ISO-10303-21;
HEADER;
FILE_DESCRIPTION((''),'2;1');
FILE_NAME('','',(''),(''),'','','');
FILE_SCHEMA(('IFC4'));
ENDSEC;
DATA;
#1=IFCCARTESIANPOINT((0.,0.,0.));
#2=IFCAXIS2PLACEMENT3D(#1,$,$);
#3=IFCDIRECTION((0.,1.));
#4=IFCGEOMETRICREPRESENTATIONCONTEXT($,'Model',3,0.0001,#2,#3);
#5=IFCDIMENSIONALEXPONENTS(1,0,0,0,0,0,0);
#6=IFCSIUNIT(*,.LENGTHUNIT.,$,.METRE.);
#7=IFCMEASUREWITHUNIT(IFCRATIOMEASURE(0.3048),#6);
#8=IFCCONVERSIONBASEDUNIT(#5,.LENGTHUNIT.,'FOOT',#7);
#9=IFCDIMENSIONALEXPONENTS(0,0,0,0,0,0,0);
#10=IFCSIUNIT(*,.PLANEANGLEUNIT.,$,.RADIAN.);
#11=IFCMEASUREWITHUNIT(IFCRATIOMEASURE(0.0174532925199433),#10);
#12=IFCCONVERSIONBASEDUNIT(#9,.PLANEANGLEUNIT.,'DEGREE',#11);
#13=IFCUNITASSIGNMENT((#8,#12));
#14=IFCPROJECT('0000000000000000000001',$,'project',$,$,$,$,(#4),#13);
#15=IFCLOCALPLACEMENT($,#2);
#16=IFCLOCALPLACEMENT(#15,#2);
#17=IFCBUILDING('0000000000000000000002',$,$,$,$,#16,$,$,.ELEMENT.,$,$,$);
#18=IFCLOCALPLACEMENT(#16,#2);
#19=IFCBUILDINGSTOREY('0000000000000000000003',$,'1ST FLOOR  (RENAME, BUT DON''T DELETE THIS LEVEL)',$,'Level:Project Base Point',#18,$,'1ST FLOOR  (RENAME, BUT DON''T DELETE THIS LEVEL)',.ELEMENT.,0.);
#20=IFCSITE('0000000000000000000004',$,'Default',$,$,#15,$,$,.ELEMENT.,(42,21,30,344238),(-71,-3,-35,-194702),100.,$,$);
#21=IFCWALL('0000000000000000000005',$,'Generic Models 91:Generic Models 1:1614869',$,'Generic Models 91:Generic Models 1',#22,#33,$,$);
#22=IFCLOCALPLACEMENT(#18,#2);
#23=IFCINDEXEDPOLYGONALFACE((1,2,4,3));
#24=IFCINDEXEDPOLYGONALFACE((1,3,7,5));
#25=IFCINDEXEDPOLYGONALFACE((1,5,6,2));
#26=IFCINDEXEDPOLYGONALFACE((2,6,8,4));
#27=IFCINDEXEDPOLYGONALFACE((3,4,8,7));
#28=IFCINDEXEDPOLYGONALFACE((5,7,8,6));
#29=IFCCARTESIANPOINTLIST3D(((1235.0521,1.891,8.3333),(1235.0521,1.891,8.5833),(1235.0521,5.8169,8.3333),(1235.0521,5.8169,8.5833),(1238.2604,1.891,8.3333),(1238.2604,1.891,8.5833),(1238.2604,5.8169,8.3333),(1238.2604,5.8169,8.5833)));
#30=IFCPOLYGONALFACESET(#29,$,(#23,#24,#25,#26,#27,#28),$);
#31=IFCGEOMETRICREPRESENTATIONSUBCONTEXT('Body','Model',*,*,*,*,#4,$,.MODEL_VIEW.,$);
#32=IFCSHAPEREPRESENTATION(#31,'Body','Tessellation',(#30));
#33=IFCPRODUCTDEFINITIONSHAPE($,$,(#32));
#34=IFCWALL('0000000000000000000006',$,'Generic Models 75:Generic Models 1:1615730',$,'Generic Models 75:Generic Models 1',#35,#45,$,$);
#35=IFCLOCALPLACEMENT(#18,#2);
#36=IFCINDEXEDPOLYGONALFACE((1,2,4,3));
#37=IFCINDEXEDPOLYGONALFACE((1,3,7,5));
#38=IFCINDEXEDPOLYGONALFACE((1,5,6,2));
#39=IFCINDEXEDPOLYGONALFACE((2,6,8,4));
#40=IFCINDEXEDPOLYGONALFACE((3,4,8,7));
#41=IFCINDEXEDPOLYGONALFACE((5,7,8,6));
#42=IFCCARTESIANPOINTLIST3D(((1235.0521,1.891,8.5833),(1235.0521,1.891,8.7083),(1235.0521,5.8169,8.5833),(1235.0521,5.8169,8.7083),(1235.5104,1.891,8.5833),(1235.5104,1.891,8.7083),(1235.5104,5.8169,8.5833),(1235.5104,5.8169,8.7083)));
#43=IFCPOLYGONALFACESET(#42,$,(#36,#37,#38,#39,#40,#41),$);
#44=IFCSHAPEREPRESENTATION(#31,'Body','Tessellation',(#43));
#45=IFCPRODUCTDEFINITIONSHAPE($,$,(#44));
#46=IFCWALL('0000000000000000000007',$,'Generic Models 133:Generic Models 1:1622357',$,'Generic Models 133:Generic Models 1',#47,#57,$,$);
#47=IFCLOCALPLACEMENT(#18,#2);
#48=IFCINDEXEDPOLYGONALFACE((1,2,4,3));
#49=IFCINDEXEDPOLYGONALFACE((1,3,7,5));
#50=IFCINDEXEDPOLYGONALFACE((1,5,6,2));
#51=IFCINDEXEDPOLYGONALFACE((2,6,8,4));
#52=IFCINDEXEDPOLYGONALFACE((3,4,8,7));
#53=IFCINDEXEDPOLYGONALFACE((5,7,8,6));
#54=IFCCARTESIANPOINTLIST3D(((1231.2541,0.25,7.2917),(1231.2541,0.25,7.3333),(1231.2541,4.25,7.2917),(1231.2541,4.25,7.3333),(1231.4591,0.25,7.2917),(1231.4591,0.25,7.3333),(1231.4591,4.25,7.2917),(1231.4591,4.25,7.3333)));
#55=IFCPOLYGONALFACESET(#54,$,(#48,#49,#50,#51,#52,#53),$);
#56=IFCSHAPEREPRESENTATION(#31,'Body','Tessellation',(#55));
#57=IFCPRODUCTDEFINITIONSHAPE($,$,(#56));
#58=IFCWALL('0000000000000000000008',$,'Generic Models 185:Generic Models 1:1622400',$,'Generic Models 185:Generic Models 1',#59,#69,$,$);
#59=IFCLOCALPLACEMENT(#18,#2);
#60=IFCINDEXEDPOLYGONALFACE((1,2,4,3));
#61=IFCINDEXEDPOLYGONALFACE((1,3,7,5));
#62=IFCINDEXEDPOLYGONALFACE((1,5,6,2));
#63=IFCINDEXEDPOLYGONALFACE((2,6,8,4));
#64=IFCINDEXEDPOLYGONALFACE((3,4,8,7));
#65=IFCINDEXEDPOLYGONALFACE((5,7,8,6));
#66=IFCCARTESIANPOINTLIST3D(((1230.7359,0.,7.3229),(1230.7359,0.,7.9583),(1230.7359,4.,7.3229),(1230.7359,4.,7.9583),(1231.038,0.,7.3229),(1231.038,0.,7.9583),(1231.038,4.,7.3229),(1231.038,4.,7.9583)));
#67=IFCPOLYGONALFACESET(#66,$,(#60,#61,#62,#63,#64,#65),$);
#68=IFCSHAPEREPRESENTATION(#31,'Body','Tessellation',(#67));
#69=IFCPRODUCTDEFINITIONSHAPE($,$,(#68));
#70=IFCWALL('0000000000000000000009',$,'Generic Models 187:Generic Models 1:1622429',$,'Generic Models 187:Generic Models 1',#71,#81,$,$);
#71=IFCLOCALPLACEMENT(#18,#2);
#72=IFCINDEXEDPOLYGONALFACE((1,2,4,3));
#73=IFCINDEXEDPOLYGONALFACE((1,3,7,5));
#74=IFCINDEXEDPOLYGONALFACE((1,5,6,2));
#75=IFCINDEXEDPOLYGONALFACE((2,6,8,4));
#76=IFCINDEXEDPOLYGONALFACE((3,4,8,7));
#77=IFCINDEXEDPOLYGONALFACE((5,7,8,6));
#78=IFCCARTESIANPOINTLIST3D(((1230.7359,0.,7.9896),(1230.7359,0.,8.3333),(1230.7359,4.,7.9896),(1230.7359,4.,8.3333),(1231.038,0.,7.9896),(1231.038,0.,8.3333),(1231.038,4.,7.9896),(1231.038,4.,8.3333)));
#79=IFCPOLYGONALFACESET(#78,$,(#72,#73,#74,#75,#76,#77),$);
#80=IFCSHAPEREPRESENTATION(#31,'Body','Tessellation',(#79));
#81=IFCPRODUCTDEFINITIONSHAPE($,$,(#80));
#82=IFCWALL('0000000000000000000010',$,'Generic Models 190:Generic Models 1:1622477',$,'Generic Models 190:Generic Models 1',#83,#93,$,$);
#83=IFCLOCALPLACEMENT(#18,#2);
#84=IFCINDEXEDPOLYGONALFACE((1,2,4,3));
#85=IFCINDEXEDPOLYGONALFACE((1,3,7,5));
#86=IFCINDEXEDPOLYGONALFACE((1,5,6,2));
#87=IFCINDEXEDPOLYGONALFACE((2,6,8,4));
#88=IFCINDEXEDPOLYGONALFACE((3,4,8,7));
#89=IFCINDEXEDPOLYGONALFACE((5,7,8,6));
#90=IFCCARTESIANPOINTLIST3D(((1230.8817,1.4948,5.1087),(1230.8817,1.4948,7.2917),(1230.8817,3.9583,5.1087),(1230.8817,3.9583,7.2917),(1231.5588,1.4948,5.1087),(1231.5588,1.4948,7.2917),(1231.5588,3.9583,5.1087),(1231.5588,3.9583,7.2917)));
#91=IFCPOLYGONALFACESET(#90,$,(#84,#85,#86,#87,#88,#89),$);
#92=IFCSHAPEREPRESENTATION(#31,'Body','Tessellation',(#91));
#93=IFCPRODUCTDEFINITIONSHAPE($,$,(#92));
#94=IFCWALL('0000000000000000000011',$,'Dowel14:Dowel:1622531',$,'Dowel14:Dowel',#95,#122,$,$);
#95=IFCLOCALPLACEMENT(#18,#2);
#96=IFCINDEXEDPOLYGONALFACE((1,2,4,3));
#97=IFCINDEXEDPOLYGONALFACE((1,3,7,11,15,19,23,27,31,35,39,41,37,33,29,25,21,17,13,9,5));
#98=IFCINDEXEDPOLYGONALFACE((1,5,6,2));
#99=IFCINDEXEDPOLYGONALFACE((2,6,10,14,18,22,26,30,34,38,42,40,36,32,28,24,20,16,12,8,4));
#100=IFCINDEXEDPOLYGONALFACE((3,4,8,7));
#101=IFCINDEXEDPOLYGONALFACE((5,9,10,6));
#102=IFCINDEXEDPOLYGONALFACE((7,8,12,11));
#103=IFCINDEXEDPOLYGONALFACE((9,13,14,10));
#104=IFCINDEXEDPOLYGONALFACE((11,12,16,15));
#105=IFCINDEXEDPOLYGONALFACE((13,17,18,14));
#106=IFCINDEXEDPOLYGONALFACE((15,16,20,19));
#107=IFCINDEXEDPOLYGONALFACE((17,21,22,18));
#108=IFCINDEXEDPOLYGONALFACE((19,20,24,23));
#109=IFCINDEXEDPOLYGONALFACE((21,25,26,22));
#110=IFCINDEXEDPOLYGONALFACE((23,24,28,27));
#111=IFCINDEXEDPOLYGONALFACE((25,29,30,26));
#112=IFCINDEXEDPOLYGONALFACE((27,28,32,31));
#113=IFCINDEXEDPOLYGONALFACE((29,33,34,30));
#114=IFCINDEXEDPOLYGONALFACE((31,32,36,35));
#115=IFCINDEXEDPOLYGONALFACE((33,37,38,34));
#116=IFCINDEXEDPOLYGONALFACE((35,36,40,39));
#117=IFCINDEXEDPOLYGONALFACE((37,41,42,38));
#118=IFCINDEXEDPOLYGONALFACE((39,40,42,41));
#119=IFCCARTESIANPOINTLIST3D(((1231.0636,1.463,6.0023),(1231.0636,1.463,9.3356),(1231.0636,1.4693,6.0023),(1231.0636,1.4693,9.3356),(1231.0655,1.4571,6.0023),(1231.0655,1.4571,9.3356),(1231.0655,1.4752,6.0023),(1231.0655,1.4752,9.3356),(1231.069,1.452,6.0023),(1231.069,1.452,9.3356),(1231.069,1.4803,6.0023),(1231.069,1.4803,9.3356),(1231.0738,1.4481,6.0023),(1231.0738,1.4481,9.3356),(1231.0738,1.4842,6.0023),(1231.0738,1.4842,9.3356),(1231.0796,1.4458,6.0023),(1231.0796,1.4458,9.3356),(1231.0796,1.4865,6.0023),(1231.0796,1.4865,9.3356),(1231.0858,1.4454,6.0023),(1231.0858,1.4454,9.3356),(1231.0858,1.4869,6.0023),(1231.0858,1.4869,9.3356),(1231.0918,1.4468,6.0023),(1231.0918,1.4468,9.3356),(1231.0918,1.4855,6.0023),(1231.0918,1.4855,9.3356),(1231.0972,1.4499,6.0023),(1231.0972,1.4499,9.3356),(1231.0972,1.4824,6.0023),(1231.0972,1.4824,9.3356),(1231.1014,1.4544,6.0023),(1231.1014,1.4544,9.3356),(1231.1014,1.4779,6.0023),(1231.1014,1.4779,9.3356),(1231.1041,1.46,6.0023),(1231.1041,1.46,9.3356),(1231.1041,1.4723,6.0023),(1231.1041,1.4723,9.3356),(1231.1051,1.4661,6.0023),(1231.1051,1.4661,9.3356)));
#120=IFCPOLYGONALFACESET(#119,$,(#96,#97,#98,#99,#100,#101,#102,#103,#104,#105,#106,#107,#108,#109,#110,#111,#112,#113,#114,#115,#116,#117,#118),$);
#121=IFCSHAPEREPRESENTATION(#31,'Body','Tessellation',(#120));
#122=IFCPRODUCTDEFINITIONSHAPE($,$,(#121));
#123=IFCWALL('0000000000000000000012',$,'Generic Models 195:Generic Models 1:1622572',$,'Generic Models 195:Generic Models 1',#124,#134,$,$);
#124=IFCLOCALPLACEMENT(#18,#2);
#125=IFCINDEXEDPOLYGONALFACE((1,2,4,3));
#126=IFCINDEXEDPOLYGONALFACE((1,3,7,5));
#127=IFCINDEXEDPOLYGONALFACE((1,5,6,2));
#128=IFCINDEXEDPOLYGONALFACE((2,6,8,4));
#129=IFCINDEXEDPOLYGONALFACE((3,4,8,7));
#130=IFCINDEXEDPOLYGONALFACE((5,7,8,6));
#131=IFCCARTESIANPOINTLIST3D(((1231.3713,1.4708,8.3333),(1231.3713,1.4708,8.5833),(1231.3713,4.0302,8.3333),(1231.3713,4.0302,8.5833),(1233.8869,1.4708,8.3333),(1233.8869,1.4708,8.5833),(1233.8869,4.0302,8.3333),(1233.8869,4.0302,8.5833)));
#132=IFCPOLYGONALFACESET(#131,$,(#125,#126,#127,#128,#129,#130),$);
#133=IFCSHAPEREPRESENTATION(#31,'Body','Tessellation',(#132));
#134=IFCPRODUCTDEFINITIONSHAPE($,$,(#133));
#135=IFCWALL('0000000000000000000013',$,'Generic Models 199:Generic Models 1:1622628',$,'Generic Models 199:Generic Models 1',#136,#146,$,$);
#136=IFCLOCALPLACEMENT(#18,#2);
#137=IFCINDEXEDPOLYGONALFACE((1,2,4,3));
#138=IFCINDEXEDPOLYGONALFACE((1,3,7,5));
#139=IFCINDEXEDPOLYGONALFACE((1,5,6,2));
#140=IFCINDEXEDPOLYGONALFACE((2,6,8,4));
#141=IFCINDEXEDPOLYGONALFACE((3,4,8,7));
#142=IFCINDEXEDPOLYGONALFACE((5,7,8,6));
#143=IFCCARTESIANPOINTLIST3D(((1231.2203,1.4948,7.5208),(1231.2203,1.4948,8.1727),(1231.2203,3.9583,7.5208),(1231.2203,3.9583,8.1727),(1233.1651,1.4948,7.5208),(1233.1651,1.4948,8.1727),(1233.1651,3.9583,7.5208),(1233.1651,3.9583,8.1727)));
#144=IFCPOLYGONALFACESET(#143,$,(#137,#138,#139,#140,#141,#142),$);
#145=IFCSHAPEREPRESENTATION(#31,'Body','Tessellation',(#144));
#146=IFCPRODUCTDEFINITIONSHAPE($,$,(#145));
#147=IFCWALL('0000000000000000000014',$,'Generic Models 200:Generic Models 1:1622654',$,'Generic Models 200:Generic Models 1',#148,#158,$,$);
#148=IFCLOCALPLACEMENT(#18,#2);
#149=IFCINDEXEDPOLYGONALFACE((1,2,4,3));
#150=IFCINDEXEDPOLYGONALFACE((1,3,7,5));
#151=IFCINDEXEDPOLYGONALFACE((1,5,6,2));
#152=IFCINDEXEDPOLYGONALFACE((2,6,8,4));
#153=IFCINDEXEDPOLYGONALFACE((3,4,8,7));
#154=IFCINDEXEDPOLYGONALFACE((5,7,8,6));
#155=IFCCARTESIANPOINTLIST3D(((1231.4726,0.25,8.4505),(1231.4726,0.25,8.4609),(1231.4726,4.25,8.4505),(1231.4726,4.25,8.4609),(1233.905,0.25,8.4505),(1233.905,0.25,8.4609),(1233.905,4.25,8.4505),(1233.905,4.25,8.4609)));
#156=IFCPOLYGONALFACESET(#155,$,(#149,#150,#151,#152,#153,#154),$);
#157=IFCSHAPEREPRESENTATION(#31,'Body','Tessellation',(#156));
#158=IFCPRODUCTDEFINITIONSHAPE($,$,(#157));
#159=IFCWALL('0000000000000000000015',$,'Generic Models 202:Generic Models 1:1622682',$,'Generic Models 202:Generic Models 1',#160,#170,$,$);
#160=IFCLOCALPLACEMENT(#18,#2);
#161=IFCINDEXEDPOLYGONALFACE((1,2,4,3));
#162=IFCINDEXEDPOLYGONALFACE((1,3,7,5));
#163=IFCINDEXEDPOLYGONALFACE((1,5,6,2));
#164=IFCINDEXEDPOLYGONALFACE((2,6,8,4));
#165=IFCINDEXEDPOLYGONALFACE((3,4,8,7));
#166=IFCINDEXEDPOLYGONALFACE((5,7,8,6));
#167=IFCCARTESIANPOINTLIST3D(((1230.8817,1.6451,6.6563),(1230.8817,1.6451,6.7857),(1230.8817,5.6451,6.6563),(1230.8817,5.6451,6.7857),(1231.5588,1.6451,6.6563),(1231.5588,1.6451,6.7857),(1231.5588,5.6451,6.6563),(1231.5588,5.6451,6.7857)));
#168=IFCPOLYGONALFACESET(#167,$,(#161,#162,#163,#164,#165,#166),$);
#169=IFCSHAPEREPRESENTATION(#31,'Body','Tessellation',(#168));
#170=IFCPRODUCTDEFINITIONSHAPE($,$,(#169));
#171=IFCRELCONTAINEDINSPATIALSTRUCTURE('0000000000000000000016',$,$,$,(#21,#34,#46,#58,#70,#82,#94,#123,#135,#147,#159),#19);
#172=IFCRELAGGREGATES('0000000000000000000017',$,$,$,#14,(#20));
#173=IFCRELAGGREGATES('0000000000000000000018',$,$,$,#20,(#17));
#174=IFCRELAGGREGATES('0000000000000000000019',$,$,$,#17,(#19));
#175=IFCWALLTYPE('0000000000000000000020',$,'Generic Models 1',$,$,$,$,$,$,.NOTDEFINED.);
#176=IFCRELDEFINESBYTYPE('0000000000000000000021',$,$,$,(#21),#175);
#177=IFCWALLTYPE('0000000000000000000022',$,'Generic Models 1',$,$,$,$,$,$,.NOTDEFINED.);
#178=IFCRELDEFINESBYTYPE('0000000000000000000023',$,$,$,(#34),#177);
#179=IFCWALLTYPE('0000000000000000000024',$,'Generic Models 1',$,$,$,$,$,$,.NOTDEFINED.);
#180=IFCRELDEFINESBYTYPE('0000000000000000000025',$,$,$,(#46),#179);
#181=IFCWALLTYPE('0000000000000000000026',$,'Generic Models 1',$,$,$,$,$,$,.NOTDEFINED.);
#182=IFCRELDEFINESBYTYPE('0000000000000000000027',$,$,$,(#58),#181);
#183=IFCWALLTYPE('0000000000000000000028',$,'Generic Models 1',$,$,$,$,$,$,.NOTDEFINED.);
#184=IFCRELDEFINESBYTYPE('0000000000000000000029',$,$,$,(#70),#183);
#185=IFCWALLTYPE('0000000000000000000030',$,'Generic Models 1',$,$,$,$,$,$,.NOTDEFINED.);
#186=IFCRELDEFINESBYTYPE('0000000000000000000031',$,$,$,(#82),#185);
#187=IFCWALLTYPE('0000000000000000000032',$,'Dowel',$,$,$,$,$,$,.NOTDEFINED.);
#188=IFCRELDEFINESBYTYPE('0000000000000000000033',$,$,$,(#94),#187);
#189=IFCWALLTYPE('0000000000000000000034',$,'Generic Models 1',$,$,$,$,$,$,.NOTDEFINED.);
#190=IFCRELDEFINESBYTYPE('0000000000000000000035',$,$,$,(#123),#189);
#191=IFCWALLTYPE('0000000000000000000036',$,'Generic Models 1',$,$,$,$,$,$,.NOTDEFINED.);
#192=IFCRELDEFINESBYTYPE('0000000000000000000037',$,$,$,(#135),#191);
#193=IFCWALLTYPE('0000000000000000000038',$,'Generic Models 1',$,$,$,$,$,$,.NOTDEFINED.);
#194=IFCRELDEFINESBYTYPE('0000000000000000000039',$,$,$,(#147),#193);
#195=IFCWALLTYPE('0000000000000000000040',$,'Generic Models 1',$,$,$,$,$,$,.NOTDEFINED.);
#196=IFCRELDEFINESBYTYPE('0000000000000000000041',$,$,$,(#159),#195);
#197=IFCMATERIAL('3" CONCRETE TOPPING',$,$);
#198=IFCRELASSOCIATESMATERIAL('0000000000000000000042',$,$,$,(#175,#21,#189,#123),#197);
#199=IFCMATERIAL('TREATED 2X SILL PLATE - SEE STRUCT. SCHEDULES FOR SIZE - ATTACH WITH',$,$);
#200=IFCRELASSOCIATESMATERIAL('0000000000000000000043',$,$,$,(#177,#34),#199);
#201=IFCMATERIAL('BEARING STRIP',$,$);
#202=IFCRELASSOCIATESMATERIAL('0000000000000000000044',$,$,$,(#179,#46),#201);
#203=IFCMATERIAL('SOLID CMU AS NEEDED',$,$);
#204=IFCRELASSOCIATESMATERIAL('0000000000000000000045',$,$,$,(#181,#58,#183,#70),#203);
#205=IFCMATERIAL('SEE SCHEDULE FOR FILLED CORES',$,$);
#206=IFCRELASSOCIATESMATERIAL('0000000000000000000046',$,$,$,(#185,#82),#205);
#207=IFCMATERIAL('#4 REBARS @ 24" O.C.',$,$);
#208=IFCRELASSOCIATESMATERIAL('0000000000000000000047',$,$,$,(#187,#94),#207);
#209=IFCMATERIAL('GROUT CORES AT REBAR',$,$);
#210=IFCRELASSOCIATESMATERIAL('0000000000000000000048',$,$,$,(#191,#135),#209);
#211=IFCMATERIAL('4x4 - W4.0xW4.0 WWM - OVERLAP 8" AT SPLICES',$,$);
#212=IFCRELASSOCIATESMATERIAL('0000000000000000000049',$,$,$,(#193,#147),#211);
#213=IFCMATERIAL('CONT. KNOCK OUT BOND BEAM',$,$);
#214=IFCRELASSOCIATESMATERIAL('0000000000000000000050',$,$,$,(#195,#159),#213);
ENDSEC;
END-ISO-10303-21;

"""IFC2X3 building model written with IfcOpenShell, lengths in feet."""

from ifc_helpers import new_model, entity, si_unit, converted_unit, direction, frame, frame_2d, origin, origin_2d_with_axis, place, context, subcontext, project, spatial, rectangle, circle, extrude, material, type_object, element, save


model = new_model("IFC2X3")

# Units and contexts
model_context = context("Model", 3, precision=0.0001, world=origin(), true_north=direction((0.0, 1.0)))
body_context = subcontext(model_context, "Body", "Model", "MODEL_VIEW")
ifc_project = project(units=[converted_unit("LENGTHUNIT", "FOOT", entity("IfcRatioMeasure", 0.3048), si_unit("LENGTHUNIT", "METRE"), dimensions=[1, 0, 0, 0, 0, 0, 0]), converted_unit("PLANEANGLEUNIT", "DEGREE", entity("IfcRatioMeasure", 0.0174532925199433), si_unit("PLANEANGLEUNIT", "RADIAN"), dimensions=[0, 0, 0, 0, 0, 0, 0])], contexts=[model_context])

# Site, building, storey
site_placement = place(None, origin())
site = spatial("IfcSite", under=ifc_project, at=site_placement, Name="Default", CompositionType="ELEMENT", RefLatitude=(42, 21, 30, 344238), RefLongitude=(-71, -3, -35, -194702), RefElevation=100.0)
building_placement = place(site_placement, origin())
building = spatial("IfcBuilding", under=site, at=building_placement, CompositionType="ELEMENT")
storey_placement = place(building_placement, origin())
storey = spatial("IfcBuildingStorey", under=building, at=storey_placement, Name="1ST FLOOR  (RENAME, BUT DON'T DELETE THIS LEVEL)", ObjectType="Level:Project Base Point", LongName="1ST FLOOR  (RENAME, BUT DON'T DELETE THIS LEVEL)", CompositionType="ELEMENT", Elevation=0.0)

# Walls
ifc_material_1 = material(Name="3\" CONCRETE TOPPING")
wall_type_1 = type_object("IfcWallType", Name="Generic Models 1", PredefinedType="NOTDEFINED", material=ifc_material_1)
wall_1_placement = place(storey_placement, frame((1235.0521, 1.891, 8.3333), z_axis=(0.0, 0.0, 1.0), x_axis=(0.0, 1.0, 0.0)))
element("IfcWall", 1, at=wall_1_placement, inside=storey, type_object=wall_type_1, material=ifc_material_1, Name="Generic Models 91:Generic Models 1:1614869", ObjectType="Generic Models 91:Generic Models 1", context=body_context, shape_type="SweptSolid", body=[
    extrude(rectangle(XDim=3.9258, YDim=3.2083, at=frame_2d((0.0, 0.0), x_axis=(1.0, 0.0))), frame((1.9629, -1.6042, 0.0)), (0.0, 0.0, 1.0), 0.25),
])
ifc_material_2 = material(Name="TREATED 2X SILL PLATE - SEE STRUCT. SCHEDULES FOR SIZE - ATTACH WITH")
wall_type_2 = type_object("IfcWallType", Name="Generic Models 1", PredefinedType="NOTDEFINED", material=ifc_material_2)
wall_2_placement = place(storey_placement, frame((1235.0521, 1.891, 8.5833), z_axis=(0.0, 0.0, 1.0), x_axis=(0.0, 1.0, 0.0)))
element("IfcWall", 2, at=wall_2_placement, inside=storey, type_object=wall_type_2, material=ifc_material_2, Name="Generic Models 75:Generic Models 1:1615730", ObjectType="Generic Models 75:Generic Models 1", context=body_context, shape_type="SweptSolid", body=[
    extrude(rectangle(XDim=3.9258, YDim=0.4583, at=frame_2d((0.0, 0.0), x_axis=(1.0, 0.0))), frame((1.9629, -0.2292, 0.0)), (0.0, 0.0, 1.0), 0.125),
])
ifc_material_3 = material(Name="BEARING STRIP")
wall_type_3 = type_object("IfcWallType", Name="Generic Models 1", PredefinedType="NOTDEFINED", material=ifc_material_3)
wall_3_placement = place(storey_placement, frame((1231.2541, 0.25, 7.2917), z_axis=(0.0, 0.0, 1.0), x_axis=(0.0, 1.0, 0.0)))
element("IfcWall", 3, at=wall_3_placement, inside=storey, type_object=wall_type_3, material=ifc_material_3, Name="Generic Models 133:Generic Models 1:1622357", ObjectType="Generic Models 133:Generic Models 1", context=body_context, shape_type="SweptSolid", body=[
    extrude(rectangle(XDim=4.0, YDim=0.205, at=frame_2d((0.0, 0.0), x_axis=(1.0, 0.0))), frame((2.0, -0.1025, 0.0)), (0.0, 0.0, 1.0), 0.0417),
])

# Walls
ifc_material_4 = material(Name="SOLID CMU AS NEEDED")
wall_type_4 = type_object("IfcWallType", Name="Generic Models 1", PredefinedType="NOTDEFINED", material=ifc_material_4)
wall_4_placement = place(storey_placement, frame((1230.7359, 0.0, 7.3229), z_axis=(0.0, 0.0, 1.0), x_axis=(0.0, 1.0, 0.0)))
element("IfcWall", 4, at=wall_4_placement, inside=storey, type_object=wall_type_4, material=ifc_material_4, Name="Generic Models 185:Generic Models 1:1622400", ObjectType="Generic Models 185:Generic Models 1", context=body_context, shape_type="SweptSolid", body=[
    extrude(rectangle(XDim=4.0, YDim=0.3021, at=frame_2d((0.0, 0.0), x_axis=(1.0, 0.0))), frame((2.0, -0.151, 0.0), z_axis=(0.0, 0.0, 1.0), x_axis=(-1.0, 0.0, 0.0)), (0.0, 0.0, 1.0), 0.6354),
])
wall_type_5 = type_object("IfcWallType", Name="Generic Models 1", PredefinedType="NOTDEFINED", material=ifc_material_4)
wall_5_placement = place(storey_placement, frame((1230.7359, 0.0, 7.9896), z_axis=(0.0, 0.0, 1.0), x_axis=(0.0, 1.0, 0.0)))
element("IfcWall", 5, at=wall_5_placement, inside=storey, type_object=wall_type_5, material=ifc_material_4, Name="Generic Models 187:Generic Models 1:1622429", ObjectType="Generic Models 187:Generic Models 1", context=body_context, shape_type="SweptSolid", body=[
    extrude(rectangle(XDim=4.0, YDim=0.3021, at=frame_2d((0.0, 0.0), x_axis=(1.0, 0.0))), frame((2.0, -0.151, 0.0), z_axis=(0.0, 0.0, 1.0), x_axis=(-1.0, 0.0, 0.0)), (0.0, 0.0, 1.0), 0.3437),
])

# Wall
ifc_material_5 = material(Name="SEE SCHEDULE FOR FILLED CORES")
wall_type_6 = type_object("IfcWallType", Name="Generic Models 1", PredefinedType="NOTDEFINED", material=ifc_material_5)
wall_6_placement = place(storey_placement, frame((1230.8817, 1.4948, 5.1087), z_axis=(0.0, 0.0, 1.0), x_axis=(0.0, 1.0, 0.0)))
element("IfcWall", 6, at=wall_6_placement, inside=storey, type_object=wall_type_6, material=ifc_material_5, Name="Generic Models 190:Generic Models 1:1622477", ObjectType="Generic Models 190:Generic Models 1", context=body_context, shape_type="SweptSolid", body=[
    extrude(rectangle(XDim=2.4635, YDim=0.6771, at=frame_2d((0.0, 0.0), x_axis=(1.0, 0.0))), frame((1.2318, -0.3385, 0.0)), (0.0, 0.0, 1.0), 2.1829),
])

# Wall
ifc_material_6 = material(Name="#4 REBARS @ 24\" O.C.")
wall_type_7 = type_object("IfcWallType", Name="Dowel", PredefinedType="NOTDEFINED", material=ifc_material_6)
wall_7_placement = place(storey_placement, frame((1231.0634, 1.4453, 6.0023), z_axis=(0.0, 0.0, 1.0), x_axis=(0.0, 1.0, 0.0)))
element("IfcWall", 7, at=wall_7_placement, inside=storey, type_object=wall_type_7, material=ifc_material_6, Name="Dowel14:Dowel:1622531", ObjectType="Dowel14:Dowel", context=body_context, shape_type="SweptSolid", body=[
    extrude(circle(Radius=0.0208, at=origin_2d_with_axis()), frame((0.0208, -0.0208, 0.0), z_axis=(0.0, 0.0, 1.0), x_axis=(0.0, -1.0, 0.0)), (0.0, 0.0, 1.0), 3.3333),
])

# Wall
wall_type_8 = type_object("IfcWallType", Name="Generic Models 1", PredefinedType="NOTDEFINED", material=ifc_material_1)
wall_8_placement = place(storey_placement, frame((1231.3713, 1.4708, 8.3333), z_axis=(0.0, 0.0, 1.0), x_axis=(0.0, 1.0, 0.0)))
element("IfcWall", 8, at=wall_8_placement, inside=storey, type_object=wall_type_8, material=ifc_material_1, Name="Generic Models 195:Generic Models 1:1622572", ObjectType="Generic Models 195:Generic Models 1", context=body_context, shape_type="SweptSolid", body=[
    extrude(rectangle(XDim=2.5594, YDim=2.5156, at=frame_2d((0.0, 0.0), x_axis=(1.0, 0.0))), frame((1.2797, -1.2578, 0.0)), (0.0, 0.0, 1.0), 0.25),
])

# Shared definitions
ifc_material_7 = material(Name="CONT. KNOCK OUT BOND BEAM")

# Walls
ifc_material_8 = material(Name="GROUT CORES AT REBAR")
wall_type_9 = type_object("IfcWallType", Name="Generic Models 1", PredefinedType="NOTDEFINED", material=ifc_material_8)
wall_9_placement = place(storey_placement, frame((1231.2203, 1.4948, 7.5208), z_axis=(0.0, 0.0, 1.0), x_axis=(0.0, 1.0, 0.0)))
element("IfcWall", 9, at=wall_9_placement, inside=storey, type_object=wall_type_9, material=ifc_material_8, Name="Generic Models 199:Generic Models 1:1622628", ObjectType="Generic Models 199:Generic Models 1", context=body_context, shape_type="SweptSolid", body=[
    extrude(rectangle(XDim=2.4635, YDim=1.9448, at=frame_2d((0.0, 0.0), x_axis=(1.0, 0.0))), frame((1.2318, -0.9724, 0.0)), (0.0, 0.0, 1.0), 0.6519),
])
ifc_material_9 = material(Name="4x4 - W4.0xW4.0 WWM - OVERLAP 8\" AT SPLICES")
wall_type_10 = type_object("IfcWallType", Name="Generic Models 1", PredefinedType="NOTDEFINED", material=ifc_material_9)
wall_10_placement = place(storey_placement, frame((1231.4726, 0.25, 8.4505), z_axis=(0.0, 0.0, 1.0), x_axis=(0.0, 1.0, 0.0)))
element("IfcWall", 10, at=wall_10_placement, inside=storey, type_object=wall_type_10, material=ifc_material_9, Name="Generic Models 200:Generic Models 1:1622654", ObjectType="Generic Models 200:Generic Models 1", context=body_context, shape_type="SweptSolid", body=[
    extrude(rectangle(XDim=4.0, YDim=2.4325, at=frame_2d((0.0, 0.0), x_axis=(1.0, 0.0))), frame((2.0, -1.2162, 0.0)), (0.0, 0.0, 1.0), 0.0104),
])
wall_type_11 = type_object("IfcWallType", Name="Generic Models 1", PredefinedType="NOTDEFINED", material=ifc_material_7)
wall_11_placement = place(storey_placement, frame((1230.8817, 1.6451, 6.6563), z_axis=(0.0, 0.0, 1.0), x_axis=(0.0, 1.0, 0.0)))
element("IfcWall", 11, at=wall_11_placement, inside=storey, type_object=wall_type_11, material=ifc_material_7, Name="Generic Models 202:Generic Models 1:1622682", ObjectType="Generic Models 202:Generic Models 1", context=body_context, shape_type="SweptSolid", body=[
    extrude(rectangle(XDim=4.0, YDim=0.6771, at=frame_2d((0.0, 0.0), x_axis=(1.0, 0.0))), frame((2.0, -0.3385, 0.0)), (0.0, 0.0, 1.0), 0.1295),
])

save(model, "model.ifc")
